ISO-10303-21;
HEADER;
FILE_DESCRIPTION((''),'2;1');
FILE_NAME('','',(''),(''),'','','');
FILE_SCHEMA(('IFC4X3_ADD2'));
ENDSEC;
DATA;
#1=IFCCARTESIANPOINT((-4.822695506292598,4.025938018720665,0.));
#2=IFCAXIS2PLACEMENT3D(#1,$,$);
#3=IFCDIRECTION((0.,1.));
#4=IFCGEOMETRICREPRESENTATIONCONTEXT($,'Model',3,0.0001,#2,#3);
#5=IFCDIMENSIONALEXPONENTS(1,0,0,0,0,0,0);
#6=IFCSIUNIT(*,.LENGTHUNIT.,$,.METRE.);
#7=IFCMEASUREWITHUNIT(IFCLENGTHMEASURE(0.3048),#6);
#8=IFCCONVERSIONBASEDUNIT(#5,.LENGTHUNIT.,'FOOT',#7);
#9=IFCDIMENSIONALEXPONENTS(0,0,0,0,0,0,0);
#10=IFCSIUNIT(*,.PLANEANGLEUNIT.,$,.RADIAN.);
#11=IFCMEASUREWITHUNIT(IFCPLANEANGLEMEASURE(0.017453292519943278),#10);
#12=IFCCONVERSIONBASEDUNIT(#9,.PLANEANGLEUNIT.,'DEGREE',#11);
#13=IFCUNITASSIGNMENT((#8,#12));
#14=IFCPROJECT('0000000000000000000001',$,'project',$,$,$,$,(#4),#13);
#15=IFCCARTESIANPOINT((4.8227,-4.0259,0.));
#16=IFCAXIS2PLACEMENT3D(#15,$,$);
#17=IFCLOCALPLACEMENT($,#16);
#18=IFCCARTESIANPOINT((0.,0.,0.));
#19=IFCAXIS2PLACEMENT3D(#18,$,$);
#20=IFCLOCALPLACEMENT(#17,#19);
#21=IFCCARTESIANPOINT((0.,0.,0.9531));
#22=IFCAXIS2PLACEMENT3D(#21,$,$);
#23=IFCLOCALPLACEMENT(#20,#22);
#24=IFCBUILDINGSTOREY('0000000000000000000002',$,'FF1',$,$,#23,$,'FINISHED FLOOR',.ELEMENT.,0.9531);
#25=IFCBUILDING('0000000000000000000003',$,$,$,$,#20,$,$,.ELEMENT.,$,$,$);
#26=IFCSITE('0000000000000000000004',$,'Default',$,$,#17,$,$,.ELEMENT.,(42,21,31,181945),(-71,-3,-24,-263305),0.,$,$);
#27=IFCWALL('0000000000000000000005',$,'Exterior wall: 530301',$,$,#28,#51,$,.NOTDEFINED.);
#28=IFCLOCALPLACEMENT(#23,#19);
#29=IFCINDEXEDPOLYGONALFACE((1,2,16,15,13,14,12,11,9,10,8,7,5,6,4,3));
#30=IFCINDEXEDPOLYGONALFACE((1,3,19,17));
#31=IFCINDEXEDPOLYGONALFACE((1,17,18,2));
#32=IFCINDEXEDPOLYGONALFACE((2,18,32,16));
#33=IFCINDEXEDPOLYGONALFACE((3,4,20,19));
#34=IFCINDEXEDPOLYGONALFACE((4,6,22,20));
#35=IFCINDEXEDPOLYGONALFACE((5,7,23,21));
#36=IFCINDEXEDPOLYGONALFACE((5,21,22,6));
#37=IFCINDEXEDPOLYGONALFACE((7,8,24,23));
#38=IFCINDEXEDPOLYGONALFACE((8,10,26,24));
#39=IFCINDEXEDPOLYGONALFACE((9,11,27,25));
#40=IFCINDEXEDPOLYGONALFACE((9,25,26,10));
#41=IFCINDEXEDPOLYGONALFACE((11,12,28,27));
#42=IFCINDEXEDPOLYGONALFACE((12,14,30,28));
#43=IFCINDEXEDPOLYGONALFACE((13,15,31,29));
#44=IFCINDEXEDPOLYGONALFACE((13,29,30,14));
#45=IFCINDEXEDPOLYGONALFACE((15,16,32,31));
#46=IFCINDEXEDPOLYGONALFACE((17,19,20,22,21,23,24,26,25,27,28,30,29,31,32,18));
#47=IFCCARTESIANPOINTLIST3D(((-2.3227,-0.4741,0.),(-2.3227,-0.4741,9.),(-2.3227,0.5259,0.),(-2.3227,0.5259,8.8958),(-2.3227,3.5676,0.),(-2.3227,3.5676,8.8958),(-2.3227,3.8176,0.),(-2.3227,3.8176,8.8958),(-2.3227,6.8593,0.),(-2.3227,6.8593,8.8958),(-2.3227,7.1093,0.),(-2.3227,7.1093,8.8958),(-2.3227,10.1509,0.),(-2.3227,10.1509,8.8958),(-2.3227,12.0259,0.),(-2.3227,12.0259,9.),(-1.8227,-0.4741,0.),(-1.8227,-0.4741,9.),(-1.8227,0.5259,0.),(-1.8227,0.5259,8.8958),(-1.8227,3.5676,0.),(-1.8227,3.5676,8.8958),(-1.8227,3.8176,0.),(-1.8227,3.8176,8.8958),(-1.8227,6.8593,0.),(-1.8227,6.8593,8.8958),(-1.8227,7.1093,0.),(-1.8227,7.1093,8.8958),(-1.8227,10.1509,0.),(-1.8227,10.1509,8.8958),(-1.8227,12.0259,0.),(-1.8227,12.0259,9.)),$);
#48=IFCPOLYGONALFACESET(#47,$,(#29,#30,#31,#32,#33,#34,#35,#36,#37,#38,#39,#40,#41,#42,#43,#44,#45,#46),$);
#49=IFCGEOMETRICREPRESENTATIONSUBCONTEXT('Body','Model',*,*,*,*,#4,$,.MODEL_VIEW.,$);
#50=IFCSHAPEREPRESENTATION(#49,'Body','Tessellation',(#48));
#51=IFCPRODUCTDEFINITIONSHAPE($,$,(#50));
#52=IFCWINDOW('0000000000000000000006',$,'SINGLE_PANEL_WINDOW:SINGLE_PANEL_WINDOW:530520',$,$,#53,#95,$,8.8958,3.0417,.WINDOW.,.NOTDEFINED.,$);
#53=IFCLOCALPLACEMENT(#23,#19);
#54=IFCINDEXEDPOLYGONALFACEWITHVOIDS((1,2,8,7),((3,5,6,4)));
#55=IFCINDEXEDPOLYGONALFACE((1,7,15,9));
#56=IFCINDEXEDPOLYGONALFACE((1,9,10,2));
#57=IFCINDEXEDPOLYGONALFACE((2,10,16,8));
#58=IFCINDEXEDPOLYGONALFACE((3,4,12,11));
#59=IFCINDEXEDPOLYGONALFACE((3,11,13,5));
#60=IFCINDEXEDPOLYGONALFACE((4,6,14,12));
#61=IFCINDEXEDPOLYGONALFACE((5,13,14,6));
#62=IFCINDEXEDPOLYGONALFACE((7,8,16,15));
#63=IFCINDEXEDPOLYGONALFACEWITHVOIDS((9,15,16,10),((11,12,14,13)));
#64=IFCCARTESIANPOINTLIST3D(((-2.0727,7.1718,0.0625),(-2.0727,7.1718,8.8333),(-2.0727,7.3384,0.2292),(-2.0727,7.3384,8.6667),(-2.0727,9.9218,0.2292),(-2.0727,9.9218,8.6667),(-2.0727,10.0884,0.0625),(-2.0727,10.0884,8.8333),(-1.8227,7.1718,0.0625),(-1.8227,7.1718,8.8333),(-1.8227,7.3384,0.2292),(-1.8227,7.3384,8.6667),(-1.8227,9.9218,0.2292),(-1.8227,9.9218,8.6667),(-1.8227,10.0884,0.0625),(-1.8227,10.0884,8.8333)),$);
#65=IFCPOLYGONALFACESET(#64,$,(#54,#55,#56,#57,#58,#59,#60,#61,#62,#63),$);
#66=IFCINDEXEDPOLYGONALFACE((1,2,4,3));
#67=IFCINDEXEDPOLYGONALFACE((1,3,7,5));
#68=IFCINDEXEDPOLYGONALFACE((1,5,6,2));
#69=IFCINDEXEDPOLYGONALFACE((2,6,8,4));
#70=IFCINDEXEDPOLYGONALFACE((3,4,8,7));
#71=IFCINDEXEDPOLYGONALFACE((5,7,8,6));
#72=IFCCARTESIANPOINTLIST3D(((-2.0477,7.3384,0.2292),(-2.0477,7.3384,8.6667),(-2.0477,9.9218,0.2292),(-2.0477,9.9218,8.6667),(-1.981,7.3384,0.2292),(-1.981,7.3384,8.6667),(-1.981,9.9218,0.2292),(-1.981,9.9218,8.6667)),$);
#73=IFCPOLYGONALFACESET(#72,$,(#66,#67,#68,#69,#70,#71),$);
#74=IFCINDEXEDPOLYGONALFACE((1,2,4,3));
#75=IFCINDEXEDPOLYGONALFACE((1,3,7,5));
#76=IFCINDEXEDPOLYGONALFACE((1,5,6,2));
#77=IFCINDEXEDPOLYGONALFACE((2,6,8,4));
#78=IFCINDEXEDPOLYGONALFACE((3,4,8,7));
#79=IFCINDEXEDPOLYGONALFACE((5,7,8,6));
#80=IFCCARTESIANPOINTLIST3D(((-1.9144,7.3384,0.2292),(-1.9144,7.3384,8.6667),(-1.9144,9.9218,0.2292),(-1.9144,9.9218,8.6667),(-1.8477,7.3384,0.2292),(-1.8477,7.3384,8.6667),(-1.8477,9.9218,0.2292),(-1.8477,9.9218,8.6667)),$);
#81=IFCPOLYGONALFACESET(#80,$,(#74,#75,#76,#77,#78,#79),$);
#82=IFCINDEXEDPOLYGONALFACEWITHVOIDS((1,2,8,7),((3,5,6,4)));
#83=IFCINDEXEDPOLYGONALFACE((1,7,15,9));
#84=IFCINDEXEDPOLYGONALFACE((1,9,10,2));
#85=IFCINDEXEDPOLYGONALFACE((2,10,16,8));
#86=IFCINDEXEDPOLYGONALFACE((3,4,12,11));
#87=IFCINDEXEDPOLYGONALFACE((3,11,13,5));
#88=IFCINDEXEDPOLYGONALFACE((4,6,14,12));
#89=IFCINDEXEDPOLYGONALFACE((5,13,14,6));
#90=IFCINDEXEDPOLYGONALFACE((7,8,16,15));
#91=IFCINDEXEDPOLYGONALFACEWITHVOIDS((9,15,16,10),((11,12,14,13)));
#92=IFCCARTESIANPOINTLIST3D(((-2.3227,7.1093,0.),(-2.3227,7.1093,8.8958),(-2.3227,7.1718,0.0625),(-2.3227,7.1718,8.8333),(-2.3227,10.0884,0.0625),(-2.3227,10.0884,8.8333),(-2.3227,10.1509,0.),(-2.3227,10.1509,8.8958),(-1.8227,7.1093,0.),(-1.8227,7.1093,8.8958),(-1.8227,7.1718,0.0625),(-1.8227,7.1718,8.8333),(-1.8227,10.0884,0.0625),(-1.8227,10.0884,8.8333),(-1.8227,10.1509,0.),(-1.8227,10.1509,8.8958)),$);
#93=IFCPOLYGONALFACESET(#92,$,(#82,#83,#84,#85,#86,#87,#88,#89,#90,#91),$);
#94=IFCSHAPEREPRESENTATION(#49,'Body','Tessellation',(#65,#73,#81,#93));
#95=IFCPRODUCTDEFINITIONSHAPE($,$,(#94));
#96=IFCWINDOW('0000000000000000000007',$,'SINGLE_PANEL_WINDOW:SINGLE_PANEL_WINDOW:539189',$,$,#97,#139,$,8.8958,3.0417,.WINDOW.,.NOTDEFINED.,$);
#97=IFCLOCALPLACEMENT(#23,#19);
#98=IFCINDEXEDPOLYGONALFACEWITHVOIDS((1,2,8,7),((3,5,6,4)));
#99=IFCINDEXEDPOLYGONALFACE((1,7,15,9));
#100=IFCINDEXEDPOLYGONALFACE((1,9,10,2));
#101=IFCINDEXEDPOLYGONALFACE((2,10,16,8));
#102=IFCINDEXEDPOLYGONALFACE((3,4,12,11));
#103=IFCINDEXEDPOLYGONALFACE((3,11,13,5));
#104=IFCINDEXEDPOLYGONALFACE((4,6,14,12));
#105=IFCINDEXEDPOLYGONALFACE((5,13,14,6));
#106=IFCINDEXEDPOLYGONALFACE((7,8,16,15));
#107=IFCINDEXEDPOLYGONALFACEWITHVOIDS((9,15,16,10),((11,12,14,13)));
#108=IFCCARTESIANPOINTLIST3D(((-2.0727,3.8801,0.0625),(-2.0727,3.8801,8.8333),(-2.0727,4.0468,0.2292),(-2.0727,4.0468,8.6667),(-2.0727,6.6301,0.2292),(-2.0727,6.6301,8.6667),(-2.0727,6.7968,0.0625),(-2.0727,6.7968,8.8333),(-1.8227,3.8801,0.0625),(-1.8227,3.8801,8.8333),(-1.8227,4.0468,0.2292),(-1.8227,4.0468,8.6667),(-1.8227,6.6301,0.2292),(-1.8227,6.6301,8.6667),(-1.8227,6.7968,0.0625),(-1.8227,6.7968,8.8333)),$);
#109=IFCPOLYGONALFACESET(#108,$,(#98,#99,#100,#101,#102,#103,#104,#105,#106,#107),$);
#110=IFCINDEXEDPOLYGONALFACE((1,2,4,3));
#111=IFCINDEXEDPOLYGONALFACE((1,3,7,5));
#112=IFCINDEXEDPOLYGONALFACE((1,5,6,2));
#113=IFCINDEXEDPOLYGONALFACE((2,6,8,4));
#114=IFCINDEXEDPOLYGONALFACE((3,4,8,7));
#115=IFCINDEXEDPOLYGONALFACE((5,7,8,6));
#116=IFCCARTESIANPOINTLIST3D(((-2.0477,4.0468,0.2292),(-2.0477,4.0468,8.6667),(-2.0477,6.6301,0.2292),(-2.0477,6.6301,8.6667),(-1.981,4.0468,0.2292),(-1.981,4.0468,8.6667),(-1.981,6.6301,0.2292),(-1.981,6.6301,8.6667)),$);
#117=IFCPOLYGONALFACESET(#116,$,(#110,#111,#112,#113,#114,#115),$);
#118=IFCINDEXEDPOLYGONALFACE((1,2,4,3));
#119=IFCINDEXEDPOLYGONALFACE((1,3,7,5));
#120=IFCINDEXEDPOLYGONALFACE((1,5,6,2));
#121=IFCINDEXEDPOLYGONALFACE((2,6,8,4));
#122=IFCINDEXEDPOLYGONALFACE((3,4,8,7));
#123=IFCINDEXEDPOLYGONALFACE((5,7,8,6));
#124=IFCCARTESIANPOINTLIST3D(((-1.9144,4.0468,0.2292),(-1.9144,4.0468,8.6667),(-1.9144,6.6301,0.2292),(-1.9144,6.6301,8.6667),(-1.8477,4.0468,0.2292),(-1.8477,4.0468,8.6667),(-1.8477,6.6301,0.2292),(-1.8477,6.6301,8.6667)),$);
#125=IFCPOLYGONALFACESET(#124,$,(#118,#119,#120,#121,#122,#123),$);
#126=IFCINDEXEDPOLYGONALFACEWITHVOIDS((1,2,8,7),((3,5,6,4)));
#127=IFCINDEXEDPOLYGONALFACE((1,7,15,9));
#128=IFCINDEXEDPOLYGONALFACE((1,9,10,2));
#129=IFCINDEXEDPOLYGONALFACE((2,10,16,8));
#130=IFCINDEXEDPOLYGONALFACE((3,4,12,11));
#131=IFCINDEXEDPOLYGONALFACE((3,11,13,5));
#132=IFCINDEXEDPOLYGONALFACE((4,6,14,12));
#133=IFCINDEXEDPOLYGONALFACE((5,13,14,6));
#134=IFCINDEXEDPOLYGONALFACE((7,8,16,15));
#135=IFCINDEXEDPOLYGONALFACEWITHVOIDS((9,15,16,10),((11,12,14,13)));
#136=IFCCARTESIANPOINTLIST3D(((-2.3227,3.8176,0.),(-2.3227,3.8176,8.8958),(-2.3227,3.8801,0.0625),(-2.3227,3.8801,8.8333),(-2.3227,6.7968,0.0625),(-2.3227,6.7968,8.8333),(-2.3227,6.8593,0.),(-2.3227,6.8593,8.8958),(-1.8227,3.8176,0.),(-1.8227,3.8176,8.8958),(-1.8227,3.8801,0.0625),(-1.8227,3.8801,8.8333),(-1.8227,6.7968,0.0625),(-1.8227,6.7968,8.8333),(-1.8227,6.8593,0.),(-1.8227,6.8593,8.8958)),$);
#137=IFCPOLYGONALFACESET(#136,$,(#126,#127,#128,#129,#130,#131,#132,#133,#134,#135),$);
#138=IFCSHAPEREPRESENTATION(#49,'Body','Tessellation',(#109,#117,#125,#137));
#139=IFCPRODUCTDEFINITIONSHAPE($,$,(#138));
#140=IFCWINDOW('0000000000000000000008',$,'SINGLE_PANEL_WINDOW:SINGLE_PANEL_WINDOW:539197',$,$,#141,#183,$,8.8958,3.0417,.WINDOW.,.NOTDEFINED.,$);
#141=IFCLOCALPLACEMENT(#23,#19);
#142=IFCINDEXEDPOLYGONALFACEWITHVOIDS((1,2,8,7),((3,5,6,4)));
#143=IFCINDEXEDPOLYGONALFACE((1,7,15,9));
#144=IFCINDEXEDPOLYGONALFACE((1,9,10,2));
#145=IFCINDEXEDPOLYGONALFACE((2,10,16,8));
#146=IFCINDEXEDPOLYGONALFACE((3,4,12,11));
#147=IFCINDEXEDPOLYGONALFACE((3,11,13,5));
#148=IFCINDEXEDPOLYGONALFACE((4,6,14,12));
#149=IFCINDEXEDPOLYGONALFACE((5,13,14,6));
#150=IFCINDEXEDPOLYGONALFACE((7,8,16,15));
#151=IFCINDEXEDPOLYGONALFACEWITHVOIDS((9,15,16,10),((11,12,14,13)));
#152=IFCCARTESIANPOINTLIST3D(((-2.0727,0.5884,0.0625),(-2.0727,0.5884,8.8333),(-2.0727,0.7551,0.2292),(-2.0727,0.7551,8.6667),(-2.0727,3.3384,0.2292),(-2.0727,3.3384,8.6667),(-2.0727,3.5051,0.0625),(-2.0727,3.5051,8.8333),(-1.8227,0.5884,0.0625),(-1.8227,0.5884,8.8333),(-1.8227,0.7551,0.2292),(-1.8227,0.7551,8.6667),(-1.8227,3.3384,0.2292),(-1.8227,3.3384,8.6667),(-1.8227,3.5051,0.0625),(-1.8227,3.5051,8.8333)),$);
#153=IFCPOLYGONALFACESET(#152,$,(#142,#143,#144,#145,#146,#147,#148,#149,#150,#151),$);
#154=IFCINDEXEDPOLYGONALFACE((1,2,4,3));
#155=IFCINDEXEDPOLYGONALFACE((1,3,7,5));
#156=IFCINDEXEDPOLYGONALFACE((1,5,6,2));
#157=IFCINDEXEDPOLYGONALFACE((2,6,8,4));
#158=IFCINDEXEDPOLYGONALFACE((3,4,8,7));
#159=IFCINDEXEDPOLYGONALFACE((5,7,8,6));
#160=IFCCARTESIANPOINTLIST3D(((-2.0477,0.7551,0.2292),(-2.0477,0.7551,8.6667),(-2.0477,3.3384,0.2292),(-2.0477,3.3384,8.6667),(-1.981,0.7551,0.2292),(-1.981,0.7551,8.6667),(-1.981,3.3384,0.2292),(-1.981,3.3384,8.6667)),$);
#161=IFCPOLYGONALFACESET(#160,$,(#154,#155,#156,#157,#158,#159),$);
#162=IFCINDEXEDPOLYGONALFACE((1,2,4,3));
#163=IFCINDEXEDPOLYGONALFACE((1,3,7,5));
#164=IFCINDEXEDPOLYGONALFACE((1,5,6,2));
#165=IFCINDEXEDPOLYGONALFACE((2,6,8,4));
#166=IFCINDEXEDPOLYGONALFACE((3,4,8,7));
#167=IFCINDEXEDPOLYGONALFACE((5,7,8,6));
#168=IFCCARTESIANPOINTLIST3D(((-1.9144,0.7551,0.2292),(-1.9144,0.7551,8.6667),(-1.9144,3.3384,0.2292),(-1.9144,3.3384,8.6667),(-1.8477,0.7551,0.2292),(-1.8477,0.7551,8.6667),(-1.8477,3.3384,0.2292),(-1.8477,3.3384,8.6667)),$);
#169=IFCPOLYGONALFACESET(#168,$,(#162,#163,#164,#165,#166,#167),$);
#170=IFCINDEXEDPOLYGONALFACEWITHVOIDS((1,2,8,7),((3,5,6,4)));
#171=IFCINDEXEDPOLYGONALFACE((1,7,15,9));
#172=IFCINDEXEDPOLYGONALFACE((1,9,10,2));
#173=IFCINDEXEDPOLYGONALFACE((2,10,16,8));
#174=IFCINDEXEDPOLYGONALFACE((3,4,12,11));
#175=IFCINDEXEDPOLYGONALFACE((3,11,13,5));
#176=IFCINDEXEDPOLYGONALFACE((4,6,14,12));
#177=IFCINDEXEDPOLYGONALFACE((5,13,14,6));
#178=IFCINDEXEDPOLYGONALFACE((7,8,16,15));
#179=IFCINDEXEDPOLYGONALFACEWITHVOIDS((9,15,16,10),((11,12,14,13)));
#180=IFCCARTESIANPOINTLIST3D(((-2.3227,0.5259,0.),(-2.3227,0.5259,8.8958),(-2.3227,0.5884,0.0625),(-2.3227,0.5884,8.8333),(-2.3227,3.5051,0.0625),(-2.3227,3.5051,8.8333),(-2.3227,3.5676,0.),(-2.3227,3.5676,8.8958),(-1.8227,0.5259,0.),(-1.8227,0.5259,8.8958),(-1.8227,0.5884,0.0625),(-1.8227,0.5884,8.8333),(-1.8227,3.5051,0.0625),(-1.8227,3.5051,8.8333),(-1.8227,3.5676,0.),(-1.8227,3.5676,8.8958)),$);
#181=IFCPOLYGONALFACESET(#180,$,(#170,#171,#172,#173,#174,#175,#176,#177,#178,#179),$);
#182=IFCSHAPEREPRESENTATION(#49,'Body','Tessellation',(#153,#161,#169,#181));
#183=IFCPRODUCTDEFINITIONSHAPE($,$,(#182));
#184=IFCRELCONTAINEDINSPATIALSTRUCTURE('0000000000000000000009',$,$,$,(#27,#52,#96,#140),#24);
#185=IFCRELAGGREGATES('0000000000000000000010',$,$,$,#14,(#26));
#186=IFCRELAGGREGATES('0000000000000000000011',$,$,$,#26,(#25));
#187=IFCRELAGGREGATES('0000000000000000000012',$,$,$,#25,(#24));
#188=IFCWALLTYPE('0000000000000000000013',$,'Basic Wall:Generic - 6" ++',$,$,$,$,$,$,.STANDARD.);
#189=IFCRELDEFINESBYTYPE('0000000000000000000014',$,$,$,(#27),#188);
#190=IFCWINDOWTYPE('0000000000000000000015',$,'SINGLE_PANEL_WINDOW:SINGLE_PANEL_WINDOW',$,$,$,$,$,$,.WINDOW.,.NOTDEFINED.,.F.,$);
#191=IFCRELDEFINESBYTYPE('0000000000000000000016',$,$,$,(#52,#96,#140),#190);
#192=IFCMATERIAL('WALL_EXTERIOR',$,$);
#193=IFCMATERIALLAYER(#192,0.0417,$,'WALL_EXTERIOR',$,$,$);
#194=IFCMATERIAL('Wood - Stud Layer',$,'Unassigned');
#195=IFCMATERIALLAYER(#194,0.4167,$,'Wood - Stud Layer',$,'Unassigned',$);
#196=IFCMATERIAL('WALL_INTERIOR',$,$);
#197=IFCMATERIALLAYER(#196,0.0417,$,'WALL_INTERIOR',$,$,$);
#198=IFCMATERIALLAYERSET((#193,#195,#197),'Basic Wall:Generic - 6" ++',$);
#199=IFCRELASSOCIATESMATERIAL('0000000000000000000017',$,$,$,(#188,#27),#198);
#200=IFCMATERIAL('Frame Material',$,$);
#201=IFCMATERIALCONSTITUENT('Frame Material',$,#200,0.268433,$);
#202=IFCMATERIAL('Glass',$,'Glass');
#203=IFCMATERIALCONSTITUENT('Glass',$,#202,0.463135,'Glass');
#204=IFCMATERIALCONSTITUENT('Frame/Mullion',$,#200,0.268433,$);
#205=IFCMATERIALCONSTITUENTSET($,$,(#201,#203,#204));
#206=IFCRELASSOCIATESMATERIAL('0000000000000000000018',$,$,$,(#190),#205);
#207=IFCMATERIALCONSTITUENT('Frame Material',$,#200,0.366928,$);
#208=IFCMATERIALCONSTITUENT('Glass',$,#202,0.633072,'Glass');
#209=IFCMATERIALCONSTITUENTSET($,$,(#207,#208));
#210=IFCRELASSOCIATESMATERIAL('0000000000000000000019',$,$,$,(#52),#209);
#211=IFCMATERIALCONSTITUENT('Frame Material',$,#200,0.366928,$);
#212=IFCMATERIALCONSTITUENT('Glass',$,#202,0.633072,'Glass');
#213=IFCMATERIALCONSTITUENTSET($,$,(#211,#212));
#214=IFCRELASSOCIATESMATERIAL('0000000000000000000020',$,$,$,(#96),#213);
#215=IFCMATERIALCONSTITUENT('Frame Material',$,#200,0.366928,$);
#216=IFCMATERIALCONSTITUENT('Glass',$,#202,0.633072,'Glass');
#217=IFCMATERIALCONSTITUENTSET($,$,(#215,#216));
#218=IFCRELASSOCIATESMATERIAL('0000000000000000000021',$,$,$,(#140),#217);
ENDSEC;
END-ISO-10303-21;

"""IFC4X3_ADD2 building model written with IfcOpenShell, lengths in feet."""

from ifc_helpers import new_model, entity, si_unit, converted_unit, direction, frame, frame_2d, origin, origin_2d_with_axis, place, context, subcontext, project, spatial, polyline, rectangle, outline, extrude, source, transform, mapped, material, layer, layer_set, constituent, constituent_set, type_object, type_shapes, element, fill, save


model = new_model("IFC4X3_ADD2")

# Units and contexts
model_context = context("Model", 3, precision=0.0001, world=frame((-4.822695506292598, 4.025938018720665, 0.0)), true_north=direction((0.0, 1.0)))
body_context = subcontext(model_context, "Body", "Model", "MODEL_VIEW")
ifc_project = project(units=[converted_unit("LENGTHUNIT", "FOOT", entity("IfcLengthMeasure", 0.3048), si_unit("LENGTHUNIT", "METRE"), dimensions=[1, 0, 0, 0, 0, 0, 0]), converted_unit("PLANEANGLEUNIT", "DEGREE", entity("IfcPlaneAngleMeasure", 0.017453292519943278), si_unit("PLANEANGLEUNIT", "RADIAN"), dimensions=[0, 0, 0, 0, 0, 0, 0])], contexts=[model_context])

# Site, building, storey
site_placement = place(None, frame((4.8227, -4.0259, 0.0)))
site = spatial("IfcSite", under=ifc_project, at=site_placement, Name="Default", CompositionType="ELEMENT", RefLatitude=(42, 21, 31, 181945), RefLongitude=(-71, -3, -24, -263305), RefElevation=0.0)
building_placement = place(site_placement, origin())
building = spatial("IfcBuilding", under=site, at=building_placement, CompositionType="ELEMENT")
storey_placement = place(building_placement, frame((0.0, 0.0, 0.9531)))
storey = spatial("IfcBuildingStorey", under=building, at=storey_placement, Name="FF1", LongName="FINISHED FLOOR", CompositionType="ELEMENT", Elevation=0.9531)

# Shared definitions
ifc_material_1 = material(Name="WALL_EXTERIOR")
ifc_layer_1 = layer(ifc_material_1, 0.0417, Name="WALL_EXTERIOR")
ifc_material_2 = material(Name="Wood - Stud Layer", Category="Unassigned")
ifc_layer_2 = layer(ifc_material_2, 0.4167, Name="Wood - Stud Layer", Category="Unassigned")
ifc_material_3 = material(Name="WALL_INTERIOR")
ifc_layer_3 = layer(ifc_material_3, 0.0417, Name="WALL_INTERIOR")
ifc_layer_set_1 = layer_set([ifc_layer_1, ifc_layer_2, ifc_layer_3], Name="Basic Wall:Generic - 6\" ++")
wall_type_1 = type_object("IfcWallType", Name="Basic Wall:Generic - 6\" ++", PredefinedType="STANDARD", material=ifc_layer_set_1)
ifc_material_4 = material(Name="Frame Material")
ifc_material_5 = material(Name="Glass", Category="Glass")

# Wall, openings, windows
wall_1_placement = place(storey_placement, frame((-2.0727, 12.0259, 0.0), z_axis=(0.0, 0.0, 1.0), x_axis=(0.0, -1.0, 0.0)))
wall_1 = element("IfcWall", 1, at=wall_1_placement, inside=storey, type_object=wall_type_1, material=ifc_layer_set_1, Name="Exterior wall: 530301", PredefinedType="NOTDEFINED", context=body_context, shape_type="SweptSolid", body=[
    extrude(rectangle(XDim=12.5, YDim=0.5, at=frame_2d((6.25, 0.0))), origin(), (0.0, 0.0, 1.0), 9.0),
])
opening_1_placement = place(wall_1_placement, frame((1.875, -0.25, 0.0)))
opening_1 = element("IfcOpeningElement", 2, at=opening_1_placement, cuts=wall_1, PredefinedType="OPENING", context=body_context, shape_type="SweptSolid", body=[
    extrude(rectangle(XDim=8.8958, YDim=3.0417, at=frame_2d((4.4479, 1.5208), x_axis=(-1.0, 0.0))), frame((0.0, 0.0, 0.0), z_axis=(0.0, 1.0, 0.0), x_axis=(0.0, 0.0, 1.0)), (0.0, 0.0, 1.0), 0.5),
])
opening_2_placement = place(wall_1_placement, frame((5.1667, -0.25, 0.0)))
opening_2 = element("IfcOpeningElement", 3, at=opening_2_placement, cuts=wall_1, PredefinedType="OPENING", context=body_context, shape_type="SweptSolid", body=[
    extrude(rectangle(XDim=8.8958, YDim=3.0417, at=frame_2d((4.4479, 1.5208), x_axis=(-1.0, 0.0))), frame((0.0, 0.0, 0.0), z_axis=(0.0, 1.0, 0.0), x_axis=(0.0, 0.0, 1.0)), (0.0, 0.0, 1.0), 0.5),
])
opening_3_placement = place(wall_1_placement, frame((8.4583, -0.25, 0.0)))
opening_3 = element("IfcOpeningElement", 4, at=opening_3_placement, cuts=wall_1, PredefinedType="OPENING", context=body_context, shape_type="SweptSolid", body=[
    extrude(rectangle(XDim=8.8958, YDim=3.0417, at=frame_2d((4.4479, 1.5208), x_axis=(-1.0, 0.0))), frame((0.0, 0.0, 0.0), z_axis=(0.0, 1.0, 0.0), x_axis=(0.0, 0.0, 1.0)), (0.0, 0.0, 1.0), 0.5),
])
ifc_constituent_1 = constituent(ifc_material_4, Name="Frame Material", fraction=0.366928)
ifc_constituent_2 = constituent(ifc_material_5, Name="Glass", Category="Glass", fraction=0.633072)
ifc_constituent_set_1 = constituent_set(constituents=[ifc_constituent_1, ifc_constituent_2])
ifc_constituent_3 = constituent(ifc_material_4, Name="Frame Material", fraction=0.268433)
ifc_constituent_4 = constituent(ifc_material_5, Name="Glass", Category="Glass", fraction=0.463135)
ifc_constituent_5 = constituent(ifc_material_4, Name="Frame/Mullion", fraction=0.268433)
ifc_constituent_set_2 = constituent_set(constituents=[ifc_constituent_3, ifc_constituent_4, ifc_constituent_5])
window_type_1 = type_object("IfcWindowType", Name="SINGLE_PANEL_WINDOW:SINGLE_PANEL_WINDOW", ParameterTakesPrecedence=False, PartitioningType="NOTDEFINED", PredefinedType="WINDOW", material=ifc_constituent_set_2)
shared_shape_1 = source(origin(), body_context, "Body", "SweptSolid", [
    extrude(outline(polyline([(-1.4583, -4.3854), (1.4583, -4.3854), (1.4583, 4.3854), (-1.4583, 4.3854), (-1.4583, -4.3854)]), holes=[polyline([(1.2917, 4.2187), (1.2917, -4.2188), (-1.2917, -4.2188), (-1.2917, 4.2187), (1.2917, 4.2187)])]), frame((1.5208, 0.5, 4.4479), z_axis=(0.0, -1.0, 0.0), x_axis=(-1.0, 0.0, 0.0)), (0.0, 0.0, 1.0), 0.25),
    extrude(rectangle(XDim=2.5833, YDim=0.0667, at=origin_2d_with_axis()), frame((1.5208, 0.3083, 0.2292), z_axis=(0.0, 0.0, 1.0), x_axis=(-1.0, 0.0, 0.0)), (0.0, 0.0, 1.0), 8.4375),
    extrude(rectangle(XDim=2.5833, YDim=0.0667, at=frame_2d((0.0, 0.0), x_axis=(1.0, 0.0))), frame((1.5208, 0.4417, 0.2292), z_axis=(0.0, 0.0, 1.0), x_axis=(-1.0, 0.0, 0.0)), (0.0, 0.0, 1.0), 8.4375),
    extrude(outline(polyline([(-4.4479, -1.5208), (4.4479, -1.5208), (4.4479, 1.5208), (-4.4479, 1.5208), (-4.4479, -1.5208)]), holes=[polyline([(-4.3854, -1.4583), (-4.3854, 1.4583), (4.3854, 1.4583), (4.3854, -1.4583), (-4.3854, -1.4583)])]), frame((1.5208, 0.5, 4.4479), z_axis=(0.0, -1.0, 0.0), x_axis=(0.0, 0.0, -1.0)), (0.0, 0.0, 1.0), 0.5),
])
type_shapes(window_type_1, [shared_shape_1])
window_1_placement = place(opening_1_placement, origin())
window_1 = element("IfcWindow", 5, at=window_1_placement, inside=storey, type_object=window_type_1, material=ifc_constituent_set_1, Name="SINGLE_PANEL_WINDOW:SINGLE_PANEL_WINDOW:530520", OverallHeight=8.8958, OverallWidth=3.0417, PartitioningType="NOTDEFINED", PredefinedType="WINDOW", context=body_context, shape_type="MappedRepresentation", body=[
    mapped(shared_shape_1, transform((0.0, 0.0, 0.0), scale=1.0)),
])
fill(opening_1, window_1)
ifc_constituent_6 = constituent(ifc_material_4, Name="Frame Material", fraction=0.366928)
ifc_constituent_7 = constituent(ifc_material_5, Name="Glass", Category="Glass", fraction=0.633072)
ifc_constituent_set_3 = constituent_set(constituents=[ifc_constituent_6, ifc_constituent_7])
window_2_placement = place(opening_2_placement, origin())
window_2 = element("IfcWindow", 6, at=window_2_placement, inside=storey, type_object=window_type_1, material=ifc_constituent_set_3, Name="SINGLE_PANEL_WINDOW:SINGLE_PANEL_WINDOW:539189", OverallHeight=8.8958, OverallWidth=3.0417, PartitioningType="NOTDEFINED", PredefinedType="WINDOW", context=body_context, shape_type="MappedRepresentation", body=[
    mapped(shared_shape_1, transform((0.0, 0.0, 0.0), scale=1.0)),
])
fill(opening_2, window_2)
ifc_constituent_8 = constituent(ifc_material_4, Name="Frame Material", fraction=0.366928)
ifc_constituent_9 = constituent(ifc_material_5, Name="Glass", Category="Glass", fraction=0.633072)
ifc_constituent_set_4 = constituent_set(constituents=[ifc_constituent_8, ifc_constituent_9])
window_3_placement = place(opening_3_placement, origin())
window_3 = element("IfcWindow", 7, at=window_3_placement, inside=storey, type_object=window_type_1, material=ifc_constituent_set_4, Name="SINGLE_PANEL_WINDOW:SINGLE_PANEL_WINDOW:539197", OverallHeight=8.8958, OverallWidth=3.0417, PartitioningType="NOTDEFINED", PredefinedType="WINDOW", context=body_context, shape_type="MappedRepresentation", body=[
    mapped(shared_shape_1, transform((0.0, 0.0, 0.0), scale=1.0)),
])
fill(opening_3, window_3)

save(model, "model.ifc")
